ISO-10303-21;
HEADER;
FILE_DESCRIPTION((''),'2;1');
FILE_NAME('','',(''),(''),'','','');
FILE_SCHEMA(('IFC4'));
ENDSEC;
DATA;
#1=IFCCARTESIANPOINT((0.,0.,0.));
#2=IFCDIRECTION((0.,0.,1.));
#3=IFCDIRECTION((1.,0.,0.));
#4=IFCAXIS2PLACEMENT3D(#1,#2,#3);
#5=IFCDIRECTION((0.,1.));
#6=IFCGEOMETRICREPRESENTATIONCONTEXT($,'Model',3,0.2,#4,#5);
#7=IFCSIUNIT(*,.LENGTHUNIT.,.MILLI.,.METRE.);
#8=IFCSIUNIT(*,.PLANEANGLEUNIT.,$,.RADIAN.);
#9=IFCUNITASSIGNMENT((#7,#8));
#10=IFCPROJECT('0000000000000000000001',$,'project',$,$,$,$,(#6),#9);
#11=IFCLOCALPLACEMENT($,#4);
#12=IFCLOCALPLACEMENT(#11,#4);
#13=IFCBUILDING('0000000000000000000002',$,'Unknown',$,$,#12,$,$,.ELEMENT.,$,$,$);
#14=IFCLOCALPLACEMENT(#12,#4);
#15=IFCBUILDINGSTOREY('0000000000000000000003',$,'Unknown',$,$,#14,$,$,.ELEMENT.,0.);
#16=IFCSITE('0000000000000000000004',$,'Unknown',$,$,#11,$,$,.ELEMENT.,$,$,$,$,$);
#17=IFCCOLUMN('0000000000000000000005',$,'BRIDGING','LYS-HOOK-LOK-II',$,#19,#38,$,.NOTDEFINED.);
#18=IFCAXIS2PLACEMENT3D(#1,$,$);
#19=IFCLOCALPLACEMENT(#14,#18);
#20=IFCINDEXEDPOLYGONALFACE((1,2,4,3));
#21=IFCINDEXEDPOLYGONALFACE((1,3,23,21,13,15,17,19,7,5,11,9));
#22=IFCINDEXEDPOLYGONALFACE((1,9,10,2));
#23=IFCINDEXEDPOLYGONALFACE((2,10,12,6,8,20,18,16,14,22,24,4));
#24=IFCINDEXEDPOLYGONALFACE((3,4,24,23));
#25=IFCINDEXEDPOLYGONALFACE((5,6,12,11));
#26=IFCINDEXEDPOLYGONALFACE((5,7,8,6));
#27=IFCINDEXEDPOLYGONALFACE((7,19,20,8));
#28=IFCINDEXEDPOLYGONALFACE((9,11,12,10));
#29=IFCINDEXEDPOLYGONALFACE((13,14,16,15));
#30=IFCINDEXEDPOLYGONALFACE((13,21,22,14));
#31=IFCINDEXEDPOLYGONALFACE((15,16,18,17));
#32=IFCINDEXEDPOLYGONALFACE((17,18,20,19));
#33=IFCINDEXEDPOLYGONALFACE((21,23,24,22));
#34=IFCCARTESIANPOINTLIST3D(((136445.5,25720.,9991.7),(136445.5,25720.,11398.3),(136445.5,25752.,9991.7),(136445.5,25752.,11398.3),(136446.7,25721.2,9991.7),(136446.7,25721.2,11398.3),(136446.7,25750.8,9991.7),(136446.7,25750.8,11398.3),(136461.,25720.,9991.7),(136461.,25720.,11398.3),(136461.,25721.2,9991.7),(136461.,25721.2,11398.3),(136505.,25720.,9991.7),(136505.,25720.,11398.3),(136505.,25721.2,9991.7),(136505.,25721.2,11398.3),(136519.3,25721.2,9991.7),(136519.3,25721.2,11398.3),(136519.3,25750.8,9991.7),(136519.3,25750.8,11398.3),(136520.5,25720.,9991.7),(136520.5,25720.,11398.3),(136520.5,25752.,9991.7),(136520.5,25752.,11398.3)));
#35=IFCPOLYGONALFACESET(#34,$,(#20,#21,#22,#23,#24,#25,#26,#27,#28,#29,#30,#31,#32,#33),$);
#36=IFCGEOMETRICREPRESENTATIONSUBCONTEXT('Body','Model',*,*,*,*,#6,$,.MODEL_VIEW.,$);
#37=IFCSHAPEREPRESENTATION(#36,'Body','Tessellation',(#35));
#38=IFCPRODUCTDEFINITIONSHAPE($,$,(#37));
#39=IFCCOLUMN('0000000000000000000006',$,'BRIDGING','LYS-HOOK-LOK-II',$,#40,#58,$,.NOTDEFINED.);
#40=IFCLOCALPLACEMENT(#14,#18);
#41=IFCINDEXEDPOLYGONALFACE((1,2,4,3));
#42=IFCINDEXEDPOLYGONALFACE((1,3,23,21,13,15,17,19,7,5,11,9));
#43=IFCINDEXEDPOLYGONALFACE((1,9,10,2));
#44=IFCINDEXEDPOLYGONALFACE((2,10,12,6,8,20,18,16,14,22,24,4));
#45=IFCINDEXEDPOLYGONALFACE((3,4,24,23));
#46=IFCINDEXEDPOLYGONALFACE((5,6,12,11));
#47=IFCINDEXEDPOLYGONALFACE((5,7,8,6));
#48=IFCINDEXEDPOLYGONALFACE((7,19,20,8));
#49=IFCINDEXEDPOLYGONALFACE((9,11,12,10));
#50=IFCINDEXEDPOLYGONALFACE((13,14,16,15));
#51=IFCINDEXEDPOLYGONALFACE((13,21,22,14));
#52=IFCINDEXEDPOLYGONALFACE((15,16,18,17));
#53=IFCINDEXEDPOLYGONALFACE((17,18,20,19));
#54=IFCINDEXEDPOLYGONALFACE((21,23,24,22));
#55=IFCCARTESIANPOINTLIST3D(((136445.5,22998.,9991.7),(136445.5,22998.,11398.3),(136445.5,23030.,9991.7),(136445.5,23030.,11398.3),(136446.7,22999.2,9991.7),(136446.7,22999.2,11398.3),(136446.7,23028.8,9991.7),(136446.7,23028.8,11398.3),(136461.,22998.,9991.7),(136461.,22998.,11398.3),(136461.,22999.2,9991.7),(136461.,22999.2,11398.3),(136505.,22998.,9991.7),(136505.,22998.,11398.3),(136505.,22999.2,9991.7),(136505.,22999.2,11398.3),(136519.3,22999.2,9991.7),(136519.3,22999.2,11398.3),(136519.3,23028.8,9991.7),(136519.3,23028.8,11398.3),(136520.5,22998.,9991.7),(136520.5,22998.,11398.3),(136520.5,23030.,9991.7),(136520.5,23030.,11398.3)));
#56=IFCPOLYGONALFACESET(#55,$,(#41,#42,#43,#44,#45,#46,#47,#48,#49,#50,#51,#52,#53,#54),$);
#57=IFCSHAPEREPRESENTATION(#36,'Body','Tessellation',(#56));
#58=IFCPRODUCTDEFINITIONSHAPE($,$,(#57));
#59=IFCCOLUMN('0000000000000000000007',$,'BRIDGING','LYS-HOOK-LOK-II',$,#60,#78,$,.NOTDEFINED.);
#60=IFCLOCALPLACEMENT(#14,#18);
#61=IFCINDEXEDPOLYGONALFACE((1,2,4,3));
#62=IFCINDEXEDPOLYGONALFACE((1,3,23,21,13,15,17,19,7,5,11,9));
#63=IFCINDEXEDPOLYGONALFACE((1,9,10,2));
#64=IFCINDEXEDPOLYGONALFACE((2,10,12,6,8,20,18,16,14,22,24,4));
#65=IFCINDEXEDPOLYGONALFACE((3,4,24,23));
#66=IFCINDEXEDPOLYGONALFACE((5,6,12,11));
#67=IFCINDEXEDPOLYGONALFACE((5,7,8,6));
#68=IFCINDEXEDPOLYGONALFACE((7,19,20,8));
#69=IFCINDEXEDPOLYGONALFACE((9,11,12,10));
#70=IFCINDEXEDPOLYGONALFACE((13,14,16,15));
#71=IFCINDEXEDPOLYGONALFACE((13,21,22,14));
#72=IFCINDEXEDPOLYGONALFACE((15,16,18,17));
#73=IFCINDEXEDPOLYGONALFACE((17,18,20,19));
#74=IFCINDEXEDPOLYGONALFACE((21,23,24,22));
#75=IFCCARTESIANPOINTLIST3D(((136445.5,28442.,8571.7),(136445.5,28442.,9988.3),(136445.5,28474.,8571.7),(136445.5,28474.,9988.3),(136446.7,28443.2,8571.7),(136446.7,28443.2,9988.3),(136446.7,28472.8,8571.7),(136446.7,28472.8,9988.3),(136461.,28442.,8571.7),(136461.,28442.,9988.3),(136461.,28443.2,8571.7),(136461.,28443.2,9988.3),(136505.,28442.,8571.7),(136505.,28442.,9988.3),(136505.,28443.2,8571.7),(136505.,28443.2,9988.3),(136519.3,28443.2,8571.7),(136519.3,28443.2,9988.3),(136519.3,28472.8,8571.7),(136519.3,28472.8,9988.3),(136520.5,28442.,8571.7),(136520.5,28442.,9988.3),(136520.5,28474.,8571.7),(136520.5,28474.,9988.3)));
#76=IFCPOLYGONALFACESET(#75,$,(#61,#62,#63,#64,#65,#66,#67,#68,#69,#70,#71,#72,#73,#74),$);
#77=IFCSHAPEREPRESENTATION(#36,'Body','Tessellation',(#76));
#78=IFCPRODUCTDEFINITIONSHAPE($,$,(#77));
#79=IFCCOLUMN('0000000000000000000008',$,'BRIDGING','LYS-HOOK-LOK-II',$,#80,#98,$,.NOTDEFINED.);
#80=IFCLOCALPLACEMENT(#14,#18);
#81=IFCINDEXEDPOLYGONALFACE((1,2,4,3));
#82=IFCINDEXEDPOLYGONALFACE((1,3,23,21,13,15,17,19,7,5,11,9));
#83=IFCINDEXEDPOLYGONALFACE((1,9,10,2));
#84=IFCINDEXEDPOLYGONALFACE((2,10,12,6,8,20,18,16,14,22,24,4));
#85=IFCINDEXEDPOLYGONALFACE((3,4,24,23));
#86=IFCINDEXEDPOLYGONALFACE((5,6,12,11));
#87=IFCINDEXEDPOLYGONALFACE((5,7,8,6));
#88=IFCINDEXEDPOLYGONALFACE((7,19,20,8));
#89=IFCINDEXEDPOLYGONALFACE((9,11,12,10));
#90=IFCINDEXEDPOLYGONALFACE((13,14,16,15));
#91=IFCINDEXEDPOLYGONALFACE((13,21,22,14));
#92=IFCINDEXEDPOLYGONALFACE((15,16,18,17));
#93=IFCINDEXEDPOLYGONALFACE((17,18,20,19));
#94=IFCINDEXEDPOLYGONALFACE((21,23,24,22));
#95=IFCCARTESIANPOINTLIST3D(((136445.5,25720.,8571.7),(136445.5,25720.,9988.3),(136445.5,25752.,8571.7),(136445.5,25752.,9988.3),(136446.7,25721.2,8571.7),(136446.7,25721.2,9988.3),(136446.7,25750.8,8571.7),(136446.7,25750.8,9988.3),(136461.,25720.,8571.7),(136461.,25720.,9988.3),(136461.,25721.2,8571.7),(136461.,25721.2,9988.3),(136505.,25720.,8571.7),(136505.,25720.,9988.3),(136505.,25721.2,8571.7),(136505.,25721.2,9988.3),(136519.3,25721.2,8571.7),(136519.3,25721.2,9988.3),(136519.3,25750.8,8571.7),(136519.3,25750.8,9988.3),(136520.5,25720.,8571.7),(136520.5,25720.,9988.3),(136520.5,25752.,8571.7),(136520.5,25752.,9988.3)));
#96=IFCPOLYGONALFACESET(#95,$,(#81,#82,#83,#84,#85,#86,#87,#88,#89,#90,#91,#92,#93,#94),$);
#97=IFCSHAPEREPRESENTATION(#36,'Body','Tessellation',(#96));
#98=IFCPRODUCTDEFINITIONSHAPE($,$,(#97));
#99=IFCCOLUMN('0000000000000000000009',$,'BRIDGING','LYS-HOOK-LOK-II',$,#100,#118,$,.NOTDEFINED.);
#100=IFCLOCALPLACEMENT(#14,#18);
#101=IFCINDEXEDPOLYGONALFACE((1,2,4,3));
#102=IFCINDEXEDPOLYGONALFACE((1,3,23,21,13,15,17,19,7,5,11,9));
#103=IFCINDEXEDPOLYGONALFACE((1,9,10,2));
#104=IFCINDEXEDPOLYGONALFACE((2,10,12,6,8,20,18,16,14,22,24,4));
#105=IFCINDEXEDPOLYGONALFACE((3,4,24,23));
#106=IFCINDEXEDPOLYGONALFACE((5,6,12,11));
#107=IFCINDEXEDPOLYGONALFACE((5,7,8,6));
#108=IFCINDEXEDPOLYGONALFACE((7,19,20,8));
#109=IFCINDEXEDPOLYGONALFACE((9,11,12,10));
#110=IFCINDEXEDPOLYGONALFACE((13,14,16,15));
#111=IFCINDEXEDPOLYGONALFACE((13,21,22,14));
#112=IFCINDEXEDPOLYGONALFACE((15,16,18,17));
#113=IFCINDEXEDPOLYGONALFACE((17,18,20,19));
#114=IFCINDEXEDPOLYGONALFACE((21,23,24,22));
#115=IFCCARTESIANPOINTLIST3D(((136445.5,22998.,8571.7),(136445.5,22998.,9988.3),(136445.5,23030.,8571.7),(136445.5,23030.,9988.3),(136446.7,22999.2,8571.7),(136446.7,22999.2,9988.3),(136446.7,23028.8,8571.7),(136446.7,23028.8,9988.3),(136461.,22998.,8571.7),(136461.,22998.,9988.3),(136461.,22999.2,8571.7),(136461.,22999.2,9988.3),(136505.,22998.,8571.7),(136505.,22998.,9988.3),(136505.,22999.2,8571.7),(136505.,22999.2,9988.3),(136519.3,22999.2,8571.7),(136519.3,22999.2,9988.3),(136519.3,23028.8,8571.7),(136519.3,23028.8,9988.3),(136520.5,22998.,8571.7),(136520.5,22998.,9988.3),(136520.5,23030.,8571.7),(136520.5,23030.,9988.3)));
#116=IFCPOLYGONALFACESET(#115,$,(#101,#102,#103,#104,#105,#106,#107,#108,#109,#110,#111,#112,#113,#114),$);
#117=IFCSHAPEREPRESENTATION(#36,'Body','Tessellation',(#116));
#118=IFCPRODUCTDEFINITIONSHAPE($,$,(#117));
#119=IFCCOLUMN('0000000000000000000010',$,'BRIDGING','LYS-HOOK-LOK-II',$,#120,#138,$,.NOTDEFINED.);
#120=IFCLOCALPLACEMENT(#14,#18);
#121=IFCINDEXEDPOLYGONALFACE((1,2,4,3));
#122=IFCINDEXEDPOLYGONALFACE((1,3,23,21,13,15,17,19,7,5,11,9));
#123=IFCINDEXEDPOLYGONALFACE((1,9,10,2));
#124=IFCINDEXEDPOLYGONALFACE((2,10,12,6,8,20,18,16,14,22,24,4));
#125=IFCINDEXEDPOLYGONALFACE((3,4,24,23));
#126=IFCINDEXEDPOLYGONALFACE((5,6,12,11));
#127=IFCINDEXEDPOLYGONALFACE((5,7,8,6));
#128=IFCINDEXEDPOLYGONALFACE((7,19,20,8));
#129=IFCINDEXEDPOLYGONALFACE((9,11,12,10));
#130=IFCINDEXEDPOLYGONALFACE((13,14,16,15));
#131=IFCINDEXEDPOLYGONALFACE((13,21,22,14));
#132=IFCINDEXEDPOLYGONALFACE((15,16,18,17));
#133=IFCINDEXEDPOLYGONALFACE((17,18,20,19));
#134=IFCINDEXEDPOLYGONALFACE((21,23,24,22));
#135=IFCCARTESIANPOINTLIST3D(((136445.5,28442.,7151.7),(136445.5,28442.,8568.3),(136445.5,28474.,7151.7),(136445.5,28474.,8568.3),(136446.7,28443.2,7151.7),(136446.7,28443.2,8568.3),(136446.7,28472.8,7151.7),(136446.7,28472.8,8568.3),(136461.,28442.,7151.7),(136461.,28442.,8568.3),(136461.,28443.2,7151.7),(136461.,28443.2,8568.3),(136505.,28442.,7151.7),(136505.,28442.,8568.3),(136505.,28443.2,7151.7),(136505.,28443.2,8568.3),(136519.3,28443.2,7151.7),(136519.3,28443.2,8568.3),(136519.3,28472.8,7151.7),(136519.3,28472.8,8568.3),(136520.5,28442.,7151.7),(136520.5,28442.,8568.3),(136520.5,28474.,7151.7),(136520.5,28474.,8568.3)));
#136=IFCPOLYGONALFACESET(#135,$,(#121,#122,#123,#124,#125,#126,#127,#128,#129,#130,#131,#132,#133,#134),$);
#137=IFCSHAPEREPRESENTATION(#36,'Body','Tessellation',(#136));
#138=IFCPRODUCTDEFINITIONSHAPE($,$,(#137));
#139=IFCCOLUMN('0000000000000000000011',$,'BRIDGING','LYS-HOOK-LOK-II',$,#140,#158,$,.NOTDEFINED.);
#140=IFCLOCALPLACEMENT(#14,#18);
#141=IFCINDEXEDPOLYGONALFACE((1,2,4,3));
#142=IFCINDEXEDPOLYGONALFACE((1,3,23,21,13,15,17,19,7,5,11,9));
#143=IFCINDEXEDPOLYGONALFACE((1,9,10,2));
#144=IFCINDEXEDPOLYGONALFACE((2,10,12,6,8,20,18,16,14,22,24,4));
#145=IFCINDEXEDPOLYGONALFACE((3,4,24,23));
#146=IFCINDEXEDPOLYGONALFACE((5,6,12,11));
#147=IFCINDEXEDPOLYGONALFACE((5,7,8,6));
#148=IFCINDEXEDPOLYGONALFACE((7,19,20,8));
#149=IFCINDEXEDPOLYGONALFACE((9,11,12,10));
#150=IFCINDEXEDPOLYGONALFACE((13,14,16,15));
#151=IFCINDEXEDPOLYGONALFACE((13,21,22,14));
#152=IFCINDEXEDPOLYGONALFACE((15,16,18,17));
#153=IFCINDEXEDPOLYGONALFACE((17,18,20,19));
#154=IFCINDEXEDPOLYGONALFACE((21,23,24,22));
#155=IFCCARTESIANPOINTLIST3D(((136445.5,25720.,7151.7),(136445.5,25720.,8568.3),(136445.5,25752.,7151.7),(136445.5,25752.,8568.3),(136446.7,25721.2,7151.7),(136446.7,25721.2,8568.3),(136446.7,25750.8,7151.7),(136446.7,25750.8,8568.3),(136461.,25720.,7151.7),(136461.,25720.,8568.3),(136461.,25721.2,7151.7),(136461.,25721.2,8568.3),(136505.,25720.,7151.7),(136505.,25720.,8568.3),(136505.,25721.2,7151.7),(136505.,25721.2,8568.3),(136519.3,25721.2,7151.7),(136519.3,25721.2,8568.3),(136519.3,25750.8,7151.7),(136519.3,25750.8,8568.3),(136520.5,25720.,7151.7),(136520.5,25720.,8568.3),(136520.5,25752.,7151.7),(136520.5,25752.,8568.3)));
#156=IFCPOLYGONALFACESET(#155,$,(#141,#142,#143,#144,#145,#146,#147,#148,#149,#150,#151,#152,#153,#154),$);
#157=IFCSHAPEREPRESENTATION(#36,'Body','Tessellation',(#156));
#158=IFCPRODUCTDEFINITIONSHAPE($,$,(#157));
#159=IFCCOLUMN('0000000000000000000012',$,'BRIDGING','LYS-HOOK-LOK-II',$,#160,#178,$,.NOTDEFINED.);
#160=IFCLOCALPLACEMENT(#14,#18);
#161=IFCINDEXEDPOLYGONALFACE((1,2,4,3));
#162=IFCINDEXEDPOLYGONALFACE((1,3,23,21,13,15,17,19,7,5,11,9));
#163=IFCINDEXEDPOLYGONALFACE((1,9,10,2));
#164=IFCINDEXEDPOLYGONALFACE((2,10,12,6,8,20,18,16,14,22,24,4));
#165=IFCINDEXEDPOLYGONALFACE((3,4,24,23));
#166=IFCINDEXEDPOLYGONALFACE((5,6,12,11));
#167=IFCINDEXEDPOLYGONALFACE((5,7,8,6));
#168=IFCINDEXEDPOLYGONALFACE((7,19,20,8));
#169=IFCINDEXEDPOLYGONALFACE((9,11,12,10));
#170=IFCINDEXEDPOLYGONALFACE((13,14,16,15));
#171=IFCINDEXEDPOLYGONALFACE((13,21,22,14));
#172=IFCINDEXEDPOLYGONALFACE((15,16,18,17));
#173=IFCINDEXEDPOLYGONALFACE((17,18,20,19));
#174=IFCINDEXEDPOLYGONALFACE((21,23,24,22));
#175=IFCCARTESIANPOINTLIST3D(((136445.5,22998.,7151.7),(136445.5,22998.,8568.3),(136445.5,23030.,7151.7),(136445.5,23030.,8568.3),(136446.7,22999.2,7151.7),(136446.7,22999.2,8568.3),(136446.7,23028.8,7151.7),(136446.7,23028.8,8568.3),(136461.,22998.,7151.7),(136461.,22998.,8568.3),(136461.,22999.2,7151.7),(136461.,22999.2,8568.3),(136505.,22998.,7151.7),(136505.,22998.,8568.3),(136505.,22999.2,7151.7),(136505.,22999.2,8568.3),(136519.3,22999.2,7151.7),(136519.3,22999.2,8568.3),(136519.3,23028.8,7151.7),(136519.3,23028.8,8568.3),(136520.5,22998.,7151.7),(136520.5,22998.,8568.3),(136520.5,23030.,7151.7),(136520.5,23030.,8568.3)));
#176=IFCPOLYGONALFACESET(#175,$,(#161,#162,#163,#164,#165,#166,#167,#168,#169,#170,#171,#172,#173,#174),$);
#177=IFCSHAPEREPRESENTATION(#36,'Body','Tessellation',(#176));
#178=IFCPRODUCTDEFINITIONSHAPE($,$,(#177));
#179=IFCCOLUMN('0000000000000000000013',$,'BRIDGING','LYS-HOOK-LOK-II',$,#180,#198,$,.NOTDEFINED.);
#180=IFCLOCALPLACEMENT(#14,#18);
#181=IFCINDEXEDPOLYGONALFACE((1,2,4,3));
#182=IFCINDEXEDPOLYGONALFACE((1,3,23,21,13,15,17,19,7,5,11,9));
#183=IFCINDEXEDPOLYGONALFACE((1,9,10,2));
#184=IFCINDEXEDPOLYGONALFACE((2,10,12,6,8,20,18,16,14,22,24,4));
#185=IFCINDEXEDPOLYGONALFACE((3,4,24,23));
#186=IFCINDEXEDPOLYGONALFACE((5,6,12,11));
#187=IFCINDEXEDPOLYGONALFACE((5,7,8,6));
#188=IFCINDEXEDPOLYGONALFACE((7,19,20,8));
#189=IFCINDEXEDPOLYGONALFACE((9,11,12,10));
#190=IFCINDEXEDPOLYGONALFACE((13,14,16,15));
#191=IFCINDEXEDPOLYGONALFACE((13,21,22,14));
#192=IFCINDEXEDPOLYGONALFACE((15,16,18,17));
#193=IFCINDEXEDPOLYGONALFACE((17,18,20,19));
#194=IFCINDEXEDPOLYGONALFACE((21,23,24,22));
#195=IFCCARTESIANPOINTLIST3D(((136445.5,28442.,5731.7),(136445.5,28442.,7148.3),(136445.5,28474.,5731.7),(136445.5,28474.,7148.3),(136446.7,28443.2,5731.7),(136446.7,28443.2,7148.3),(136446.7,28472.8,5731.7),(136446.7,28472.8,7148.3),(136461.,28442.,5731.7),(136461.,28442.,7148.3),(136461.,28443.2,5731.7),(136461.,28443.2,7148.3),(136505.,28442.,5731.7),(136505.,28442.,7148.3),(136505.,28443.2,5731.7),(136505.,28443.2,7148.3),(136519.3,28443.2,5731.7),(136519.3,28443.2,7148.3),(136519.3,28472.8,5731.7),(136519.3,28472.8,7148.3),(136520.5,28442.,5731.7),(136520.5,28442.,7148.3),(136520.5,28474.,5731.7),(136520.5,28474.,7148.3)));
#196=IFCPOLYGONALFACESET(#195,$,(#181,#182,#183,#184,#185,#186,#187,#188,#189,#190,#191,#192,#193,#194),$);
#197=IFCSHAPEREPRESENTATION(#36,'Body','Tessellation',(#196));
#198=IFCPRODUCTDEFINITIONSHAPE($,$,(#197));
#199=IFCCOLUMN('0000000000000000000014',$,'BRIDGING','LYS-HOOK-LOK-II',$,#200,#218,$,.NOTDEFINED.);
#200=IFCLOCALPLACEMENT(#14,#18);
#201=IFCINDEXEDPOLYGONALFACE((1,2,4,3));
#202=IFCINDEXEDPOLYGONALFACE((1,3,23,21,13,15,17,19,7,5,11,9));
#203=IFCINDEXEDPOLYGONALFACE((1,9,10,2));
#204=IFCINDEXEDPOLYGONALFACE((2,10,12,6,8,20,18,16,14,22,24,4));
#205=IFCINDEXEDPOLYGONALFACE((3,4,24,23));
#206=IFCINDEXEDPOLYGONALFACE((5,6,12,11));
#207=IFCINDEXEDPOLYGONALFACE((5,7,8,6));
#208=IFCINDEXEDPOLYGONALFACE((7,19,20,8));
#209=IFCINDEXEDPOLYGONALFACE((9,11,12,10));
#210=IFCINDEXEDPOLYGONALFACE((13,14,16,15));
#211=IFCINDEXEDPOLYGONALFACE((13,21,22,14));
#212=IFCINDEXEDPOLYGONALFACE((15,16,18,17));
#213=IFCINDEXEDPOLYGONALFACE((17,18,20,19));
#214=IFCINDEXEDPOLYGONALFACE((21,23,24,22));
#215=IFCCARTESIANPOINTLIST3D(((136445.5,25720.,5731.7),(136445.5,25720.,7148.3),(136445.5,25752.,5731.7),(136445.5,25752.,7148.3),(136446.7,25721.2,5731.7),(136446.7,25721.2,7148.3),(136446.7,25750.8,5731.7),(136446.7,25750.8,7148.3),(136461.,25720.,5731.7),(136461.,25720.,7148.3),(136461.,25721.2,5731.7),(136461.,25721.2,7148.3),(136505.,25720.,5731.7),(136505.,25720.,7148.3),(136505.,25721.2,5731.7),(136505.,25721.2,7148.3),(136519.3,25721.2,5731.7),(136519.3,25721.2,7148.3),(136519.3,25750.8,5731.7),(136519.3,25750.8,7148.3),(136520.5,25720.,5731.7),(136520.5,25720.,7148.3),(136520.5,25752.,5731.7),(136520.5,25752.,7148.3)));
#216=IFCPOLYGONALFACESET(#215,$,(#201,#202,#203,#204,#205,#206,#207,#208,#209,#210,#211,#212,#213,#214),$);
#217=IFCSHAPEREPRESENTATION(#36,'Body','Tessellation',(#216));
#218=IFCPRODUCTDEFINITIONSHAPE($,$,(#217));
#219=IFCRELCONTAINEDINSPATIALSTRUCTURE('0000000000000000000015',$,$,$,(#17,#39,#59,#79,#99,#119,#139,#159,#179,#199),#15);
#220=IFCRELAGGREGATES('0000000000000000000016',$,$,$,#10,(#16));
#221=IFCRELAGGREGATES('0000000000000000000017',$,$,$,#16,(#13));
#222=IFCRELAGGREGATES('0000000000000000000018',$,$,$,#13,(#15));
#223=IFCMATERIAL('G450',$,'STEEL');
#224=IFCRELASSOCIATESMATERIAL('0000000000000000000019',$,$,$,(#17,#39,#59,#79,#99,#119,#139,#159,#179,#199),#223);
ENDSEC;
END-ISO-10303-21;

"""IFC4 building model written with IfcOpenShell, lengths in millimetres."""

from ifc_helpers import new_model, si_unit, direction, frame, origin_with_axes, place, context, subcontext, project, spatial, line, indexed_curve, outline, extrude, material, element, save


model = new_model("IFC4")

# Units and contexts
model_context = context("Model", 3, precision=0.2, world=origin_with_axes(), true_north=direction((0.0, 1.0)))
body_context = subcontext(model_context, "Body", "Model", "MODEL_VIEW")
ifc_project = project(units=[si_unit("LENGTHUNIT", "METRE", prefix="MILLI"), si_unit("PLANEANGLEUNIT", "RADIAN")], contexts=[model_context])

# Site, building, storey
site_placement = place(None, origin_with_axes())
site = spatial("IfcSite", under=ifc_project, at=site_placement, Name="Unknown", CompositionType="ELEMENT")
building_placement = place(site_placement, origin_with_axes())
building = spatial("IfcBuilding", under=site, at=building_placement, Name="Unknown", CompositionType="ELEMENT")
storey_placement = place(building_placement, origin_with_axes())
storey = spatial("IfcBuildingStorey", under=building, at=storey_placement, Name="Unknown", CompositionType="ELEMENT", Elevation=0.0)

# Columns
ifc_material_1 = material(Name="G450", Category="STEEL")
for number, where, z_axis, x_axis, name in (
    (1, (136483.0, 25736.0, 9991.7), (0.0, -1.0, 0.0), (0.0, 0.0, 1.0), "BRIDGING"),
    (2, (136483.0, 23014.0, 9991.7), (0.0, -1.0, 0.0), (0.0, 0.0, 1.0), "BRIDGING"),
):
    element("IfcColumn", number, at=place(storey_placement, frame(where, z_axis=z_axis, x_axis=x_axis)), inside=storey, material=ifc_material_1, Name=name, Description="LYS-HOOK-LOK-II", PredefinedType="NOTDEFINED", context=body_context, shape_type="SolidModel", body=[
        extrude(outline(indexed_curve([(16.0, -37.5), (16.0, -22.0), (14.8, -22.0), (14.8, -36.3), (-14.8, -36.3), (-14.8, 36.3), (14.8, 36.3), (14.8, 22.0), (16.0, 22.0), (16.0, 37.5), (-16.0, 37.5), (-16.0, -37.5)], segments=[line(1, 2, 3, 4, 5, 6, 7, 8, 9, 10, 11, 12, 1)])), frame((0.0, 0.0, 0.0), z_axis=(-1.0, 0.0, 0.0), x_axis=(0.0, 0.0, 1.0)), (0.0, 0.0, -1.0), 1406.6),
    ])
for number, where, z_axis, x_axis, name in (
    (3, (136483.0, 28458.0, 8571.7), (0.0, -1.0, 0.0), (0.0, 0.0, 1.0), "BRIDGING"),
    (4, (136483.0, 25736.0, 8571.7), (0.0, -1.0, 0.0), (0.0, 0.0, 1.0), "BRIDGING"),
    (5, (136483.0, 23014.0, 8571.7), (0.0, -1.0, 0.0), (0.0, 0.0, 1.0), "BRIDGING"),
    (6, (136483.0, 28458.0, 7151.7), (0.0, -1.0, 0.0), (0.0, 0.0, 1.0), "BRIDGING"),
    (7, (136483.0, 25736.0, 7151.7), (0.0, -1.0, 0.0), (0.0, 0.0, 1.0), "BRIDGING"),
    (8, (136483.0, 23014.0, 7151.7), (0.0, -1.0, 0.0), (0.0, 0.0, 1.0), "BRIDGING"),
    (9, (136483.0, 28458.0, 5731.7), (0.0, -1.0, 0.0), (0.0, 0.0, 1.0), "BRIDGING"),
    (10, (136483.0, 25736.0, 5731.7), (0.0, -1.0, 0.0), (0.0, 0.0, 1.0), "BRIDGING"),
):
    element("IfcColumn", number, at=place(storey_placement, frame(where, z_axis=z_axis, x_axis=x_axis)), inside=storey, material=ifc_material_1, Name=name, Description="LYS-HOOK-LOK-II", PredefinedType="NOTDEFINED", context=body_context, shape_type="SolidModel", body=[
        extrude(outline(indexed_curve([(16.0, -37.5), (16.0, -22.0), (14.8, -22.0), (14.8, -36.3), (-14.8, -36.3), (-14.8, 36.3), (14.8, 36.3), (14.8, 22.0), (16.0, 22.0), (16.0, 37.5), (-16.0, 37.5), (-16.0, -37.5)], segments=[line(1, 2, 3, 4, 5, 6, 7, 8, 9, 10, 11, 12, 1)])), frame((0.0, 0.0, 0.0), z_axis=(-1.0, 0.0, 0.0), x_axis=(0.0, 0.0, 1.0)), (0.0, 0.0, -1.0), 1416.6),
    ])

save(model, "model.ifc")
